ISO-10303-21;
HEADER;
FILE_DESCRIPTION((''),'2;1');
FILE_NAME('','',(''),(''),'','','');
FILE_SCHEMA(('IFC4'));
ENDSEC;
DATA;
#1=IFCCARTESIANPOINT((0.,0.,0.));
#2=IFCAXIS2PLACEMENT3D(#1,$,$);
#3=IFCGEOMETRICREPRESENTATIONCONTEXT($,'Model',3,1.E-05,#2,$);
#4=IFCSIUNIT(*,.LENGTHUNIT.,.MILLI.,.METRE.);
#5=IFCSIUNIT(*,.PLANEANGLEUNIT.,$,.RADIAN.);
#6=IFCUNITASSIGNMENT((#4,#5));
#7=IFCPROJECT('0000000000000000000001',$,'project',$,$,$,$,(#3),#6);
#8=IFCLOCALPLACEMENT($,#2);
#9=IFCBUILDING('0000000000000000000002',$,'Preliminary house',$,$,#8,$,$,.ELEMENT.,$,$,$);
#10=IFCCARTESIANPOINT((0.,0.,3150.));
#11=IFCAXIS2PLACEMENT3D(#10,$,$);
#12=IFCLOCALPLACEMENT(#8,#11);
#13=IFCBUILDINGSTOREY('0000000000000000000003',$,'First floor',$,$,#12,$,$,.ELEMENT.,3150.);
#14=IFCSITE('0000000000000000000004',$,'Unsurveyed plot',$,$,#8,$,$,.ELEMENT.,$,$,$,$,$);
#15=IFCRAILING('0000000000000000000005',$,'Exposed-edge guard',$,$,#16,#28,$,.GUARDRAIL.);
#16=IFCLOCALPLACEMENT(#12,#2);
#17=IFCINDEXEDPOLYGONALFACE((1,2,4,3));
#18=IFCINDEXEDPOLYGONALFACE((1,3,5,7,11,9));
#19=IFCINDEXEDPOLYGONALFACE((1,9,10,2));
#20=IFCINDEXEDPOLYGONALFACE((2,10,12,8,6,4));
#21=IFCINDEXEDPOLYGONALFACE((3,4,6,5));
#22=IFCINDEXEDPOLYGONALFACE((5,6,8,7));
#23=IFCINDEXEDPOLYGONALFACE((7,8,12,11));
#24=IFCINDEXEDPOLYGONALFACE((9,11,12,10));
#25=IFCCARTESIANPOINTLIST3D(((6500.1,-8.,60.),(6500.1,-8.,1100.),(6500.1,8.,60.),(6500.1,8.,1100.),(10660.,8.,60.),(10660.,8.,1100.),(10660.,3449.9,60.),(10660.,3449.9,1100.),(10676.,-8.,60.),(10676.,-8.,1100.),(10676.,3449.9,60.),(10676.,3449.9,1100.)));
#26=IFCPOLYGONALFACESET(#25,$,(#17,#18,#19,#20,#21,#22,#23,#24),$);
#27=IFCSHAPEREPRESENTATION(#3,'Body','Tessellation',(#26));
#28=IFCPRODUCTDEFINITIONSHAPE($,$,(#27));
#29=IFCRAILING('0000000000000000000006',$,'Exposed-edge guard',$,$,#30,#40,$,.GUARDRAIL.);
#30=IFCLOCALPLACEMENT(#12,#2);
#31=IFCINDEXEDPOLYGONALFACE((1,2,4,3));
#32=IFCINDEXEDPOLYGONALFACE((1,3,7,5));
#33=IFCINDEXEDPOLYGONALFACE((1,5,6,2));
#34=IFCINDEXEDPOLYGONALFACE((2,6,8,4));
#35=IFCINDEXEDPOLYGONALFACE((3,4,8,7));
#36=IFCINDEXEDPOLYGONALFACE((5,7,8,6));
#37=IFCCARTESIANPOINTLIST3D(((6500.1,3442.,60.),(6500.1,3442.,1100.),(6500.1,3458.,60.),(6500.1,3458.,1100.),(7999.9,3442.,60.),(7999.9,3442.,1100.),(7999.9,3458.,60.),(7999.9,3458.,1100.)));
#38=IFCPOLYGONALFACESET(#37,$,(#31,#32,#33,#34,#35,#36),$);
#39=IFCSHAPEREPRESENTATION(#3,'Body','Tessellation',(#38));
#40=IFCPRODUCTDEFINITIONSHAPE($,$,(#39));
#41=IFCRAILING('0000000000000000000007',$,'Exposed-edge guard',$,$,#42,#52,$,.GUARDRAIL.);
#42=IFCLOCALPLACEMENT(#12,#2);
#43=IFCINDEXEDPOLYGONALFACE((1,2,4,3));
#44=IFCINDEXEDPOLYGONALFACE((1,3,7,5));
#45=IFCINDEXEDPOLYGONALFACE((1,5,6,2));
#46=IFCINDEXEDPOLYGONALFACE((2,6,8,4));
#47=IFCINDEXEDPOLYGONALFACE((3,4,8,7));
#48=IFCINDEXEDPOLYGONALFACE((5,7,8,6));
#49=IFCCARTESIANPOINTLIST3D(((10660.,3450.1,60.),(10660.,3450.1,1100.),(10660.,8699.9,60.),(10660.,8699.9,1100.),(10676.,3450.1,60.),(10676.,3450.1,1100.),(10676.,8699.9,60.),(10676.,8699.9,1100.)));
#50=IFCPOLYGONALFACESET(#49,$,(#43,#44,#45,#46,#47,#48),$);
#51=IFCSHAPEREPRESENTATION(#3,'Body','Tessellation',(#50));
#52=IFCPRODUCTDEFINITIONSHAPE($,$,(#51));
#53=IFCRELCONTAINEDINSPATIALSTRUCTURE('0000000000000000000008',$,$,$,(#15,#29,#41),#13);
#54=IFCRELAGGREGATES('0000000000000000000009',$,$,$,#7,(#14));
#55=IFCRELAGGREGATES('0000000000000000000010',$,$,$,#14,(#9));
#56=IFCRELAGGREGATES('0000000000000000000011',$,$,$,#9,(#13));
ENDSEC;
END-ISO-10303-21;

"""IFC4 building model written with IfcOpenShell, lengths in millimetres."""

from ifc_helpers import new_model, si_unit, frame, origin, place, context, project, spatial, polyline, outline, extrude, element, save


model = new_model("IFC4")

# Units and contexts
model_context = context("Model", 3, precision=1e-05, world=origin())
ifc_project = project(units=[si_unit("LENGTHUNIT", "METRE", prefix="MILLI"), si_unit("PLANEANGLEUNIT", "RADIAN")], contexts=[model_context])

# Site, building, storey
placement_1 = place(None, origin())
site = spatial("IfcSite", under=ifc_project, at=placement_1, Name="Unsurveyed plot", CompositionType="ELEMENT")
building = spatial("IfcBuilding", under=site, at=placement_1, Name="Preliminary house", CompositionType="ELEMENT")
placement_2 = place(placement_1, frame((0.0, 0.0, 3150.0)))
storey = spatial("IfcBuildingStorey", under=building, at=placement_2, Name="First floor", CompositionType="ELEMENT", Elevation=3150.0)

# Railings
element("IfcRailing", 1, at=placement_2, inside=storey, Name="Exposed-edge guard", PredefinedType="GUARDRAIL", context=model_context, shape_type="SweptSolid", body=[
    extrude(outline(polyline([(10660.0, 8.0), (10660.0, 3449.9), (10676.0, 3449.9), (10676.0, -8.0), (6500.1, -8.0), (6500.1, 8.0), (10660.0, 8.0)])), frame((0.0, 0.0, 60.0)), (0.0, 0.0, 1.0), 1040.0),
])
element("IfcRailing", 2, at=placement_2, inside=storey, Name="Exposed-edge guard", PredefinedType="GUARDRAIL", context=model_context, shape_type="SweptSolid", body=[
    extrude(outline(polyline([(6500.1, 3442.0), (6500.1, 3458.0), (7999.9, 3458.0), (7999.9, 3442.0), (6500.1, 3442.0)])), frame((0.0, 0.0, 60.0)), (0.0, 0.0, 1.0), 1040.0),
])
element("IfcRailing", 3, at=placement_2, inside=storey, Name="Exposed-edge guard", PredefinedType="GUARDRAIL", context=model_context, shape_type="SweptSolid", body=[
    extrude(outline(polyline([(10660.0, 8699.9), (10676.0, 8699.9), (10676.0, 3450.1), (10660.0, 3450.1), (10660.0, 8699.9)])), frame((0.0, 0.0, 60.0)), (0.0, 0.0, 1.0), 1040.0),
])

save(model, "model.ifc")
